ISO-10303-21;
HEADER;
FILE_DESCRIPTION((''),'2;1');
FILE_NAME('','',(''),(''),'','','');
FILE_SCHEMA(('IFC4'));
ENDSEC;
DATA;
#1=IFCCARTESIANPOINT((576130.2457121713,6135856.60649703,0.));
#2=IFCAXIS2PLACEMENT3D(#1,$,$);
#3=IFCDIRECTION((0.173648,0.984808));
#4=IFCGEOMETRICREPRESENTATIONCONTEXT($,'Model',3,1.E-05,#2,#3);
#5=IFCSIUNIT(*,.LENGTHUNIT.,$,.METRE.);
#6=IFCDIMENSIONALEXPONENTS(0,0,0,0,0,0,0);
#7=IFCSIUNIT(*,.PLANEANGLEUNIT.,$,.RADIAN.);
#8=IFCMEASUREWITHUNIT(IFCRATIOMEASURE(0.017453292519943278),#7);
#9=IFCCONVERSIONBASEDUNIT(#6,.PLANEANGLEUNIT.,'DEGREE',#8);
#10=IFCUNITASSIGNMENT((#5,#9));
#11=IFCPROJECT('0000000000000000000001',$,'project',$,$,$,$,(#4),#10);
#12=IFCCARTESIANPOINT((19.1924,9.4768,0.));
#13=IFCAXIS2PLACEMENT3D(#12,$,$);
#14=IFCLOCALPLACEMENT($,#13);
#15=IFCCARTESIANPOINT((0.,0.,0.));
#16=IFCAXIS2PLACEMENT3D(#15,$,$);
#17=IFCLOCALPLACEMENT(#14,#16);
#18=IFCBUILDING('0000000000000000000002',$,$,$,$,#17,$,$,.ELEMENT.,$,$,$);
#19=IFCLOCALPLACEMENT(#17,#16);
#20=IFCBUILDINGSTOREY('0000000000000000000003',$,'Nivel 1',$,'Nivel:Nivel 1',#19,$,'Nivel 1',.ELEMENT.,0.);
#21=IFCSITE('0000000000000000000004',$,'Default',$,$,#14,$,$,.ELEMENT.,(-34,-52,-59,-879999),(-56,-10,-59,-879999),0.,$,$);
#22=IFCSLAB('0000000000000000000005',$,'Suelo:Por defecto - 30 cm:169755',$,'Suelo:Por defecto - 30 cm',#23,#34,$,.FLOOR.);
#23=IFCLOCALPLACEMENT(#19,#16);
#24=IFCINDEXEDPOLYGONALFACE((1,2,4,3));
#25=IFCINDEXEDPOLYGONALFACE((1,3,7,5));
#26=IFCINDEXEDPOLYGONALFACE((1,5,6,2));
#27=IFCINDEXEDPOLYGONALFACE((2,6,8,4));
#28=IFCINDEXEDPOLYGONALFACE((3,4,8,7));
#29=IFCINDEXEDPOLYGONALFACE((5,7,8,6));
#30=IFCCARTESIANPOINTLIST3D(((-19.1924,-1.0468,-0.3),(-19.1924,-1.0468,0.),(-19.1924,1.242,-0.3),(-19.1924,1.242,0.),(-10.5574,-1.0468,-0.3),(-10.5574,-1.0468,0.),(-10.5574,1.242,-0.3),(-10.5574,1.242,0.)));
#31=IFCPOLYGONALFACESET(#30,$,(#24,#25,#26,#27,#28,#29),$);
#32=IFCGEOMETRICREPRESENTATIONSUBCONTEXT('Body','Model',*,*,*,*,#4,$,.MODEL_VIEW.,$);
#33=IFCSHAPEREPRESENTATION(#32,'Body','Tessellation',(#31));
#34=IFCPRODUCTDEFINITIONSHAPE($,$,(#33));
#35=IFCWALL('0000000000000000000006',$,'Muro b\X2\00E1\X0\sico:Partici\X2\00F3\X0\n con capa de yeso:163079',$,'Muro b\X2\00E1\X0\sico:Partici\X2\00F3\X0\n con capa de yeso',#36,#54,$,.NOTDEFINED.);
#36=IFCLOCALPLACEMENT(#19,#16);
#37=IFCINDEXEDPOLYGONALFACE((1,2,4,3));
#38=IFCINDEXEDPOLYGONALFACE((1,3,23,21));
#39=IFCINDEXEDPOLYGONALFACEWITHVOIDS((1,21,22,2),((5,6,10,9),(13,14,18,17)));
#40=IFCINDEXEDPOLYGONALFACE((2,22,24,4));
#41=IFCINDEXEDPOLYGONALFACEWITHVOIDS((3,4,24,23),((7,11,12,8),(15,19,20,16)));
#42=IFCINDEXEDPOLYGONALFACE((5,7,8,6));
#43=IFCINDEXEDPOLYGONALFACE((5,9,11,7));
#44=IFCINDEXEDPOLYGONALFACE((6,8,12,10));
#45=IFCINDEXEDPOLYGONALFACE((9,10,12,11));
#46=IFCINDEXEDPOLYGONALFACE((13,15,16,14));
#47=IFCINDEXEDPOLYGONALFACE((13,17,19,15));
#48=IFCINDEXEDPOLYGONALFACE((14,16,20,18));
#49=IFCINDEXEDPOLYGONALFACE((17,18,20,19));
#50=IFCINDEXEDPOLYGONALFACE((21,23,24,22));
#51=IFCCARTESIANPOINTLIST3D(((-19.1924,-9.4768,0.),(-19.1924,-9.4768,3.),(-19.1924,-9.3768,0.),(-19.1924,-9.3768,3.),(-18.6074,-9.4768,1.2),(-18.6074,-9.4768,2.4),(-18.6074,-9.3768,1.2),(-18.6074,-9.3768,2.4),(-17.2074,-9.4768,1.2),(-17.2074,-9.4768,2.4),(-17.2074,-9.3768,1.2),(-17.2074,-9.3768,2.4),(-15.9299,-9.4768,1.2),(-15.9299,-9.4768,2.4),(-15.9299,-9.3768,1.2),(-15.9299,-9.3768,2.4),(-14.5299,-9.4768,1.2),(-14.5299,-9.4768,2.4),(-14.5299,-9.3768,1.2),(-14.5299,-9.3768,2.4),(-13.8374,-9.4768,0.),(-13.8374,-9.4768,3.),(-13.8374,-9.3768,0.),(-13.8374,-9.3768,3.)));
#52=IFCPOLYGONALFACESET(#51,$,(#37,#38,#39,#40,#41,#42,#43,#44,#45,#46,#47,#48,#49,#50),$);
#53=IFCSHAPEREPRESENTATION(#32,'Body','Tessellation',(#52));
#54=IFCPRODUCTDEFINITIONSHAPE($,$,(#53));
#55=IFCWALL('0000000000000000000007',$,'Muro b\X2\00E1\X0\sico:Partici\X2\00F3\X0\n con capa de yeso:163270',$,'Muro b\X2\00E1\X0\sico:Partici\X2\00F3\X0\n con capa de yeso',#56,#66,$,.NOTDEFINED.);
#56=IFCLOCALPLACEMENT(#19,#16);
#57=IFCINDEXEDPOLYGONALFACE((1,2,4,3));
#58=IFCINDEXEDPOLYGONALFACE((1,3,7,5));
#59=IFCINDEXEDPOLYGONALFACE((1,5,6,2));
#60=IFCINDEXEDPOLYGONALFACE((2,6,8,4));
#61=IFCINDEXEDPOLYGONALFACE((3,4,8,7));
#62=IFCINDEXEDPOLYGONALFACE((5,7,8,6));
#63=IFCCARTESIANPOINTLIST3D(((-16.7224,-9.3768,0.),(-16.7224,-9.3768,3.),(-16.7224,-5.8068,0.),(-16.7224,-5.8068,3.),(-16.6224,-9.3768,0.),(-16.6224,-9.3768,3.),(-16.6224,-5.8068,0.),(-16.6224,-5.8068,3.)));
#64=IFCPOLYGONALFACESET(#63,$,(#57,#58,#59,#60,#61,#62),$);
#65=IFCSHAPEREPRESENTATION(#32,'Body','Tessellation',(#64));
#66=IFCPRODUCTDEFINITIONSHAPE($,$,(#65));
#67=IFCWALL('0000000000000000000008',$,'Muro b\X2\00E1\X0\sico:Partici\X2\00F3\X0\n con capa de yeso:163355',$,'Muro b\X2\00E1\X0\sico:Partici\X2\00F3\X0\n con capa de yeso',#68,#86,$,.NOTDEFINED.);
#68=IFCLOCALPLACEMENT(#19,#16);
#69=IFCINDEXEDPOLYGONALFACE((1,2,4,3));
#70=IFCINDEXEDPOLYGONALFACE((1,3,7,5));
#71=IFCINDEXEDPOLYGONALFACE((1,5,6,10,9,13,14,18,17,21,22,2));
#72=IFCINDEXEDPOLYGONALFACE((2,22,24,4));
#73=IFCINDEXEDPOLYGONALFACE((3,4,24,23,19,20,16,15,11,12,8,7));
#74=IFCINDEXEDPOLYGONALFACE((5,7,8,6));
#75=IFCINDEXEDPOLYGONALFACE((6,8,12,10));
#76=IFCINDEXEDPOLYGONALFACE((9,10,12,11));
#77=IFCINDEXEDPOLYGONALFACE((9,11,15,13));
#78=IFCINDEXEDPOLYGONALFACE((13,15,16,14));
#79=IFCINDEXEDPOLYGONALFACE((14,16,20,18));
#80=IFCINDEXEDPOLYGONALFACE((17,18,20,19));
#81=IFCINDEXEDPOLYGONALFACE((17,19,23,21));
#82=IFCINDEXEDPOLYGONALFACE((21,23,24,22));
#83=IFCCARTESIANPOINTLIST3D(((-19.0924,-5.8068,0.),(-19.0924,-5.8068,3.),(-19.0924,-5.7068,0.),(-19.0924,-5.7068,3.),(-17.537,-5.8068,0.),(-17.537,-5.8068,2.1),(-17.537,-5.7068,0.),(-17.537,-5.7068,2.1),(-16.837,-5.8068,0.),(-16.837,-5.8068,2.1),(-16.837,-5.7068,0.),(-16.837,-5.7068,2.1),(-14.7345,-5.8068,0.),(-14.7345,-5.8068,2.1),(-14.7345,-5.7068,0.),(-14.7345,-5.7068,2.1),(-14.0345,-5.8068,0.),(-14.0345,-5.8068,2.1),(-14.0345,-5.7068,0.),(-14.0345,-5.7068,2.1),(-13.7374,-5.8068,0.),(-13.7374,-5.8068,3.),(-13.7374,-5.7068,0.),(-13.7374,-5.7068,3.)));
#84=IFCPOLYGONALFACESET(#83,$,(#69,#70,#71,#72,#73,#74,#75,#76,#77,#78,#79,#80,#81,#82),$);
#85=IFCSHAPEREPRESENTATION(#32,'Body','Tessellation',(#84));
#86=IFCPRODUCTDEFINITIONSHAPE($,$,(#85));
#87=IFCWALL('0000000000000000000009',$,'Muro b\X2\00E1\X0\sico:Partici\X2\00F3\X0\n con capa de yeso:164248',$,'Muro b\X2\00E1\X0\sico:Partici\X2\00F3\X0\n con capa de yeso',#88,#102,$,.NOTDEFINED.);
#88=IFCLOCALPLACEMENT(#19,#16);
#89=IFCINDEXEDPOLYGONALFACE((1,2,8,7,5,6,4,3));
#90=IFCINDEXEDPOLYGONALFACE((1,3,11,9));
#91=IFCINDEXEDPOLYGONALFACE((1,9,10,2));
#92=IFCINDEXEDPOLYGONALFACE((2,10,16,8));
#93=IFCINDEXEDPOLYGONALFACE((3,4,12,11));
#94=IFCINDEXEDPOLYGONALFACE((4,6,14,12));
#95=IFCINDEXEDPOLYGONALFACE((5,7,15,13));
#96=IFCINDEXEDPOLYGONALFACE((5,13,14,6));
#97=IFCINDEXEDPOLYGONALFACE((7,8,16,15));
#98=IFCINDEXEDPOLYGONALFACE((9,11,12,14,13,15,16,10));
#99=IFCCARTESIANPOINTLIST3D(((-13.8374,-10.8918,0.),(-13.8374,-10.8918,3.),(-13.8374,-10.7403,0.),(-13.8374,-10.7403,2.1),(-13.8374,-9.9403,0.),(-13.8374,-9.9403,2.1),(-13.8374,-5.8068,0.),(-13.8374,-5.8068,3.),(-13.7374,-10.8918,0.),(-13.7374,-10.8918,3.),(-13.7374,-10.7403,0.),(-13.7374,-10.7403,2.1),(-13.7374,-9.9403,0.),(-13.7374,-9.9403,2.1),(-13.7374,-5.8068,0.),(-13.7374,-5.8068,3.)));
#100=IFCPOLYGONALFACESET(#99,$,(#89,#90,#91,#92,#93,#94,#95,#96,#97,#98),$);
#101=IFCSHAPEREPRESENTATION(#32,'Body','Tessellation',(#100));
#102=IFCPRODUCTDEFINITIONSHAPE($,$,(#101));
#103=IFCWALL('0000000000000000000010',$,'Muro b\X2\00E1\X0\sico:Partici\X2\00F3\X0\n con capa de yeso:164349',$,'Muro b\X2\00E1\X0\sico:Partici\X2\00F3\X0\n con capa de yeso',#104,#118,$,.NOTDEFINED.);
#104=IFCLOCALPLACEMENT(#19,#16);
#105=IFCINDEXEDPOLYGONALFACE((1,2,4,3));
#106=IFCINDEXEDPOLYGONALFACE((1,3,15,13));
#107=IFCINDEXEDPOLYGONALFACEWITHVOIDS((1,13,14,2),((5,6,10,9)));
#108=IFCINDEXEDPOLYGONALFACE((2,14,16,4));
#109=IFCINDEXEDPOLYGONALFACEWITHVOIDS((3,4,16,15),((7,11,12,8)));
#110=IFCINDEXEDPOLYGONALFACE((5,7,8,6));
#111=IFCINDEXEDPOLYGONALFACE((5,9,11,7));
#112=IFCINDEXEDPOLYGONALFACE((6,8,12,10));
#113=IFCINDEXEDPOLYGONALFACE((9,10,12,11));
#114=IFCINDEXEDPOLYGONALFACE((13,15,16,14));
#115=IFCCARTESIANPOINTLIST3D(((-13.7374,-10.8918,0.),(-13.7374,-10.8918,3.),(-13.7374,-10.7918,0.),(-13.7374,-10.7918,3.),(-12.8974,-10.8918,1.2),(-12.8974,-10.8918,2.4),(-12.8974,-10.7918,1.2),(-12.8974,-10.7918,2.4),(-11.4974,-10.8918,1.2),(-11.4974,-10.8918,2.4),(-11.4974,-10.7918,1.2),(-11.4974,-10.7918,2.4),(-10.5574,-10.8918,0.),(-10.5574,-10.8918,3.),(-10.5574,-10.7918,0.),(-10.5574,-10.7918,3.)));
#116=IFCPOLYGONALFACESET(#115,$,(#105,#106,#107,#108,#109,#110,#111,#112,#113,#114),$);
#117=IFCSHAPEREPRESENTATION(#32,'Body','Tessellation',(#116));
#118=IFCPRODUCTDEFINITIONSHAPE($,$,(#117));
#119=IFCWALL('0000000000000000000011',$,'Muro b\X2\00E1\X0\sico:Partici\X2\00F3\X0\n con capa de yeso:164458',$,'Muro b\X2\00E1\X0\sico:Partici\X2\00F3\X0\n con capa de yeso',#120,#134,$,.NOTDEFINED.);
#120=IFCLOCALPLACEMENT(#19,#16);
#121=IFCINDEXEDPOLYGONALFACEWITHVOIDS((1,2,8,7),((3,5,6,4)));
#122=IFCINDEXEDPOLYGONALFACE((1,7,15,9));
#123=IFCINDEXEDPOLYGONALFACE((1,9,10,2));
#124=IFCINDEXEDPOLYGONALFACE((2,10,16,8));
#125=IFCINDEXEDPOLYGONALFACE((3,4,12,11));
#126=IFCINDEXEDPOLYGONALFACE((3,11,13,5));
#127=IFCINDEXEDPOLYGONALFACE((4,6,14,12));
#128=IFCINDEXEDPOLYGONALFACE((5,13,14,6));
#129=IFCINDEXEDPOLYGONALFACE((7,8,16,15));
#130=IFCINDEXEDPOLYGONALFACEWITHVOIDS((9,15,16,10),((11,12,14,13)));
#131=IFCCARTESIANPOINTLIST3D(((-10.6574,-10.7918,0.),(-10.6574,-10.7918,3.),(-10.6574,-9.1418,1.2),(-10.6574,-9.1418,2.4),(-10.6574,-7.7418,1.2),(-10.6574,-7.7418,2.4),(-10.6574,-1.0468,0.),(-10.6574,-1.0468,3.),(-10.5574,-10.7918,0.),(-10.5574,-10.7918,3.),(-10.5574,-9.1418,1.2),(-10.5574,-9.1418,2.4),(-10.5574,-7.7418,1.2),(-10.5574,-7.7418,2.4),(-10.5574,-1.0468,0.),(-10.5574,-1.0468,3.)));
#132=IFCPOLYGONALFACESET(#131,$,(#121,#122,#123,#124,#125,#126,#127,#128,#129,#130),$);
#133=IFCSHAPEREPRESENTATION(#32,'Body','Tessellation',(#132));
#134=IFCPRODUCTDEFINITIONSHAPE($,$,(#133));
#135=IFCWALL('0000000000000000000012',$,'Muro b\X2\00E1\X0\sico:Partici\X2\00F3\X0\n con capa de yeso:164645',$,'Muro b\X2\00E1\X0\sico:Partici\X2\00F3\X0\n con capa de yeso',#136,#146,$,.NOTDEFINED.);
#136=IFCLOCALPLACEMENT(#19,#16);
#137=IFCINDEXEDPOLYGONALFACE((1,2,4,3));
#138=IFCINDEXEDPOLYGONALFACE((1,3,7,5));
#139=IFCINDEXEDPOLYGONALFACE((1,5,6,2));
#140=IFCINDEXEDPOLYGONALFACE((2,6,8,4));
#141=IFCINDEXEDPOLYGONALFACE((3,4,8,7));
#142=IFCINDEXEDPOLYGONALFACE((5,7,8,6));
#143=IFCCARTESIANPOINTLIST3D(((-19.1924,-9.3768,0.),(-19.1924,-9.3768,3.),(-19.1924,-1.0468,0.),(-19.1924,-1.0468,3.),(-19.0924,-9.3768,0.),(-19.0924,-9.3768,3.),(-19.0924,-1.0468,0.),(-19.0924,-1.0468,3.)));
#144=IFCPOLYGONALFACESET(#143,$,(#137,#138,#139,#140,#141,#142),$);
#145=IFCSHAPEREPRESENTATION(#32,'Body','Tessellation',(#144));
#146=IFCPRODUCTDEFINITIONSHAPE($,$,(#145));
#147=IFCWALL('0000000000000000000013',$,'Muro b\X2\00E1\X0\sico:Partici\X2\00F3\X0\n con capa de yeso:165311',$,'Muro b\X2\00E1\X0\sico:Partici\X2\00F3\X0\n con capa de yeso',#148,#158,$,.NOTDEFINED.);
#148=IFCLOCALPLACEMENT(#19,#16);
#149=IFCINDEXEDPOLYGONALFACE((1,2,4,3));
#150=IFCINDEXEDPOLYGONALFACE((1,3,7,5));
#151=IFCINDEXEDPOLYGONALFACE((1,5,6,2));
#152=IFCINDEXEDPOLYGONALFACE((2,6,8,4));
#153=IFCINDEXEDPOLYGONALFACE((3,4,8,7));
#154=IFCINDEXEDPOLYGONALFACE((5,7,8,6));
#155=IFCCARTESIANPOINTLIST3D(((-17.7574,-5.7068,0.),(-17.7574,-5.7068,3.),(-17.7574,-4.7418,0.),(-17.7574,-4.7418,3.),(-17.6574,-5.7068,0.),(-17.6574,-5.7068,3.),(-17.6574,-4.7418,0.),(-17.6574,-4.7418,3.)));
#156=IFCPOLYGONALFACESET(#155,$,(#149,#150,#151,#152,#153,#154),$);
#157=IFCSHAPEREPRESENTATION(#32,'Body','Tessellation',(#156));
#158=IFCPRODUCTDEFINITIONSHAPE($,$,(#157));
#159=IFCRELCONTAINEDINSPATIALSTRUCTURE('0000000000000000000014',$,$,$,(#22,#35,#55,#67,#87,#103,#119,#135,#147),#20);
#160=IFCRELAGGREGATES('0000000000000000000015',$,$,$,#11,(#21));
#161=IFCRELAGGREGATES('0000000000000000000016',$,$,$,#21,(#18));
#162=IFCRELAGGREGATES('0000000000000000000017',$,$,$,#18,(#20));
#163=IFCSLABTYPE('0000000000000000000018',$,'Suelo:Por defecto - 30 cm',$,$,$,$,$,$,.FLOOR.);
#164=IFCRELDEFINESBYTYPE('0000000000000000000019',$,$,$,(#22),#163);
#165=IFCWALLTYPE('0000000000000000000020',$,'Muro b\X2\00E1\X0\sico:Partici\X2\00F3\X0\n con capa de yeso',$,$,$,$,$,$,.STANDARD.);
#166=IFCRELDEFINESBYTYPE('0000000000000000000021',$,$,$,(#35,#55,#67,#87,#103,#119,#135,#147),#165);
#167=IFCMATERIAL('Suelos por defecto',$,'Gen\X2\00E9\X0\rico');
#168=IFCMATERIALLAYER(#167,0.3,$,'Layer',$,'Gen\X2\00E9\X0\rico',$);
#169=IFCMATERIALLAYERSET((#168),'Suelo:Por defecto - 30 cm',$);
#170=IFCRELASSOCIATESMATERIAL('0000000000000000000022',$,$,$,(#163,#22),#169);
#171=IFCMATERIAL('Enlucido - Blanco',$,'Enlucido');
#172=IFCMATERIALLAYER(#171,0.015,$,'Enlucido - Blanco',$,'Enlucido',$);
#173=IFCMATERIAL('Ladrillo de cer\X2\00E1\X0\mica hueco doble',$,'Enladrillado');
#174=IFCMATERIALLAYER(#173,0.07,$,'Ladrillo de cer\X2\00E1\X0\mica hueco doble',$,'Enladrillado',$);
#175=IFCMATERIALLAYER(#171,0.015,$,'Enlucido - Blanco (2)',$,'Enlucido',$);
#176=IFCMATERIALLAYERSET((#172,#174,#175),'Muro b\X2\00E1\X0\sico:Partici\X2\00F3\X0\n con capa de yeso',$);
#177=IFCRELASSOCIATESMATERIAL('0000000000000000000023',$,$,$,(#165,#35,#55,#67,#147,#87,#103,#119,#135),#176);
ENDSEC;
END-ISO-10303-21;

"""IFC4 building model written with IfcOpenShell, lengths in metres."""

from ifc_helpers import new_model, entity, si_unit, converted_unit, direction, frame, frame_2d, origin, origin_2d_with_axis, place, context, subcontext, project, spatial, rectangle, extrude, material, layer, layer_set, layer_usage, type_object, element, save


model = new_model("IFC4")

# Units and contexts
model_context = context("Model", 3, precision=1e-05, world=frame((576130.2457121713, 6135856.60649703, 0.0)), true_north=direction((0.173648, 0.984808)))
body_context = subcontext(model_context, "Body", "Model", "MODEL_VIEW")
ifc_project = project(units=[si_unit("LENGTHUNIT", "METRE"), converted_unit("PLANEANGLEUNIT", "DEGREE", entity("IfcRatioMeasure", 0.017453292519943278), si_unit("PLANEANGLEUNIT", "RADIAN"), dimensions=[0, 0, 0, 0, 0, 0, 0])], contexts=[model_context])

# Site, building, storey
site_placement = place(None, frame((19.1924, 9.4768, 0.0)))
site = spatial("IfcSite", under=ifc_project, at=site_placement, Name="Default", CompositionType="ELEMENT", RefLatitude=(-34, -52, -59, -879999), RefLongitude=(-56, -10, -59, -879999), RefElevation=0.0)
building_placement = place(site_placement, origin())
building = spatial("IfcBuilding", under=site, at=building_placement, CompositionType="ELEMENT")
storey_placement = place(building_placement, origin())
storey = spatial("IfcBuildingStorey", under=building, at=storey_placement, Name="Nivel 1", ObjectType="Nivel:Nivel 1", LongName="Nivel 1", CompositionType="ELEMENT", Elevation=0.0)

# Slab
ifc_material_1 = material(Name="Suelos por defecto", Category="Genérico")
ifc_layer_1 = layer(ifc_material_1, 0.3, Name="Layer", Category="Genérico")
ifc_layer_set_1 = layer_set([ifc_layer_1], Name="Suelo:Por defecto - 30 cm")
ifc_layer_usage_1 = layer_usage(ifc_layer_set_1, "AXIS3", "POSITIVE", 0.0)
slab_type = type_object("IfcSlabType", Name="Suelo:Por defecto - 30 cm", PredefinedType="FLOOR", material=ifc_layer_set_1)
slab_1_placement = place(storey_placement, origin())
element("IfcSlab", 1, at=slab_1_placement, inside=storey, type_object=slab_type, material=ifc_layer_usage_1, Name="Suelo:Por defecto - 30 cm:169755", ObjectType="Suelo:Por defecto - 30 cm", PredefinedType="FLOOR", context=body_context, shape_type="SweptSolid", body=[
    extrude(rectangle(XDim=2.2888, YDim=8.635, at=origin_2d_with_axis()), frame((-14.8749, 0.0976, 0.0), z_axis=(0.0, 0.0, -1.0), x_axis=(0.0, 1.0, 0.0)), (0.0, 0.0, 1.0), 0.3),
])

# Wall, openings
ifc_material_2 = material(Name="Enlucido - Blanco", Category="Enlucido")
ifc_layer_2 = layer(ifc_material_2, 0.015, Name="Enlucido - Blanco", Category="Enlucido")
ifc_material_3 = material(Name="Ladrillo de cerámica hueco doble", Category="Enladrillado")
ifc_layer_3 = layer(ifc_material_3, 0.07, Name="Ladrillo de cerámica hueco doble", Category="Enladrillado")
ifc_layer_4 = layer(ifc_material_2, 0.015, Name="Enlucido - Blanco (2)", Category="Enlucido")
ifc_layer_set_2 = layer_set([ifc_layer_2, ifc_layer_3, ifc_layer_4], Name="Muro básico:Partición con capa de yeso")
ifc_layer_usage_2 = layer_usage(ifc_layer_set_2, "AXIS2", "NEGATIVE", 0.05)
wall_type = type_object("IfcWallType", Name="Muro básico:Partición con capa de yeso", PredefinedType="STANDARD", material=ifc_layer_set_2)
wall_1_placement = place(storey_placement, frame((-19.1924, -9.4268, 0.0)))
wall_1 = element("IfcWall", 2, at=wall_1_placement, inside=storey, type_object=wall_type, material=ifc_layer_usage_2, Name="Muro básico:Partición con capa de yeso:163079", ObjectType="Muro básico:Partición con capa de yeso", PredefinedType="NOTDEFINED", context=body_context, shape_type="SweptSolid", body=[
    extrude(rectangle(XDim=5.355, YDim=0.1, at=frame_2d((2.6775, 0.0), x_axis=(-1.0, 0.0))), origin(), (0.0, 0.0, 1.0), 3.0),
])
opening_1_placement = place(wall_1_placement, frame((0.585, -0.05, 1.2)))
element("IfcOpeningElement", 3, at=opening_1_placement, cuts=wall_1, PredefinedType="OPENING", context=body_context, shape_type="SweptSolid", body=[
    extrude(rectangle(XDim=1.2, YDim=1.4, at=frame_2d((0.6, 0.7), x_axis=(1.0, 0.0))), frame((0.0, 0.0, 0.0), z_axis=(0.0, 1.0, 0.0), x_axis=(0.0, 0.0, 1.0)), (0.0, 0.0, 1.0), 0.1),
])
opening_2_placement = place(wall_1_placement, frame((3.2625, -0.05, 1.2)))
element("IfcOpeningElement", 4, at=opening_2_placement, cuts=wall_1, PredefinedType="OPENING", context=body_context, shape_type="SweptSolid", body=[
    extrude(rectangle(XDim=1.2, YDim=1.4, at=frame_2d((0.6, 0.7), x_axis=(1.0, 0.0))), frame((0.0, 0.0, 0.0), z_axis=(0.0, 1.0, 0.0), x_axis=(0.0, 0.0, 1.0)), (0.0, 0.0, 1.0), 0.1),
])

# Wall
wall_2_placement = place(storey_placement, frame((-16.6724, -9.3768, 0.0), z_axis=(0.0, 0.0, 1.0), x_axis=(0.0, 1.0, 0.0)))
element("IfcWall", 5, at=wall_2_placement, inside=storey, type_object=wall_type, material=ifc_layer_usage_2, Name="Muro básico:Partición con capa de yeso:163270", ObjectType="Muro básico:Partición con capa de yeso", PredefinedType="NOTDEFINED", context=body_context, shape_type="SweptSolid", body=[
    extrude(rectangle(XDim=3.57, YDim=0.1, at=frame_2d((1.785, 0.0), x_axis=(-1.0, 0.0))), origin(), (0.0, 0.0, 1.0), 3.0),
])

# Wall, openings
wall_3_placement = place(storey_placement, frame((-13.7374, -5.7568, 0.0), z_axis=(0.0, 0.0, 1.0), x_axis=(-1.0, 0.0, 0.0)))
wall_3 = element("IfcWall", 6, at=wall_3_placement, inside=storey, type_object=wall_type, material=ifc_layer_usage_2, Name="Muro básico:Partición con capa de yeso:163355", ObjectType="Muro básico:Partición con capa de yeso", PredefinedType="NOTDEFINED", context=body_context, shape_type="SweptSolid", body=[
    extrude(rectangle(XDim=5.355, YDim=0.1, at=frame_2d((2.6775, 0.0), x_axis=(-1.0, 0.0))), origin(), (0.0, 0.0, 1.0), 3.0),
])
opening_3_placement = place(wall_3_placement, frame((3.0996, -0.05, 0.0)))
element("IfcOpeningElement", 7, at=opening_3_placement, cuts=wall_3, PredefinedType="OPENING", context=body_context, shape_type="SweptSolid", body=[
    extrude(rectangle(XDim=2.1, YDim=0.7, at=frame_2d((1.05, 0.35), x_axis=(1.0, 0.0))), frame((0.0, 0.0, 0.0), z_axis=(0.0, 1.0, 0.0), x_axis=(0.0, 0.0, 1.0)), (0.0, 0.0, 1.0), 0.1),
])
opening_4_placement = place(wall_3_placement, frame((0.2971, -0.05, 0.0)))
element("IfcOpeningElement", 8, at=opening_4_placement, cuts=wall_3, PredefinedType="OPENING", context=body_context, shape_type="SweptSolid", body=[
    extrude(rectangle(XDim=2.1, YDim=0.7, at=frame_2d((1.05, 0.35), x_axis=(1.0, 0.0))), frame((0.0, 0.0, 0.0), z_axis=(0.0, 1.0, 0.0), x_axis=(0.0, 0.0, 1.0)), (0.0, 0.0, 1.0), 0.1),
])

# Walls, openings
ifc_layer_usage_3 = layer_usage(ifc_layer_set_2, "AXIS2", "POSITIVE", -0.05)
wall_4_placement = place(storey_placement, frame((-13.7874, -5.8068, 0.0), z_axis=(0.0, 0.0, 1.0), x_axis=(0.0, -1.0, 0.0)))
wall_4 = element("IfcWall", 9, at=wall_4_placement, inside=storey, type_object=wall_type, material=ifc_layer_usage_3, Name="Muro básico:Partición con capa de yeso:164248", ObjectType="Muro básico:Partición con capa de yeso", PredefinedType="NOTDEFINED", context=body_context, shape_type="SweptSolid", body=[
    extrude(rectangle(XDim=5.085, YDim=0.1, at=frame_2d((2.5425, 0.0), x_axis=(1.0, 0.0))), origin(), (0.0, 0.0, 1.0), 3.0),
])
opening_5_placement = place(wall_4_placement, frame((4.1335, -0.05, 0.0)))
element("IfcOpeningElement", 10, at=opening_5_placement, cuts=wall_4, PredefinedType="OPENING", context=body_context, shape_type="SweptSolid", body=[
    extrude(rectangle(XDim=2.1, YDim=0.8, at=frame_2d((1.05, 0.4), x_axis=(1.0, 0.0))), frame((0.0, 0.0, 0.0), z_axis=(0.0, 1.0, 0.0), x_axis=(0.0, 0.0, 1.0)), (0.0, 0.0, 1.0), 0.1),
])
wall_5_placement = place(storey_placement, frame((-13.7374, -10.8418, 0.0)))
wall_5 = element("IfcWall", 11, at=wall_5_placement, inside=storey, type_object=wall_type, material=ifc_layer_usage_3, Name="Muro básico:Partición con capa de yeso:164349", ObjectType="Muro básico:Partición con capa de yeso", PredefinedType="NOTDEFINED", context=body_context, shape_type="SweptSolid", body=[
    extrude(rectangle(XDim=3.18, YDim=0.1, at=frame_2d((1.59, 0.0), x_axis=(-1.0, 0.0))), origin(), (0.0, 0.0, 1.0), 3.0),
])
opening_6_placement = place(wall_5_placement, frame((0.84, -0.05, 1.2)))
element("IfcOpeningElement", 12, at=opening_6_placement, cuts=wall_5, PredefinedType="OPENING", context=body_context, shape_type="SweptSolid", body=[
    extrude(rectangle(XDim=1.2, YDim=1.4, at=frame_2d((0.6, 0.7), x_axis=(1.0, 0.0))), frame((0.0, 0.0, 0.0), z_axis=(0.0, 1.0, 0.0), x_axis=(0.0, 0.0, 1.0)), (0.0, 0.0, 1.0), 0.1),
])
wall_6_placement = place(storey_placement, frame((-10.6074, -10.7918, 0.0), z_axis=(0.0, 0.0, 1.0), x_axis=(0.0, 1.0, 0.0)))
wall_6 = element("IfcWall", 13, at=wall_6_placement, inside=storey, type_object=wall_type, material=ifc_layer_usage_3, Name="Muro básico:Partición con capa de yeso:164458", ObjectType="Muro básico:Partición con capa de yeso", PredefinedType="NOTDEFINED", context=body_context, shape_type="SweptSolid", body=[
    extrude(rectangle(XDim=9.745, YDim=0.1, at=frame_2d((4.8725, 0.0), x_axis=(-1.0, 0.0))), origin(), (0.0, 0.0, 1.0), 3.0),
])
opening_7_placement = place(wall_6_placement, frame((1.65, -0.05, 1.2)))
element("IfcOpeningElement", 14, at=opening_7_placement, cuts=wall_6, PredefinedType="OPENING", context=body_context, shape_type="SweptSolid", body=[
    extrude(rectangle(XDim=1.2, YDim=1.4, at=frame_2d((0.6, 0.7), x_axis=(1.0, 0.0))), frame((0.0, 0.0, 0.0), z_axis=(0.0, 1.0, 0.0), x_axis=(0.0, 0.0, 1.0)), (0.0, 0.0, 1.0), 0.1),
])

# Walls
wall_7_placement = place(storey_placement, frame((-19.1424, -1.0468, 0.0), z_axis=(0.0, 0.0, 1.0), x_axis=(0.0, -1.0, 0.0)))
element("IfcWall", 15, at=wall_7_placement, inside=storey, type_object=wall_type, material=ifc_layer_usage_3, Name="Muro básico:Partición con capa de yeso:164645", ObjectType="Muro básico:Partición con capa de yeso", PredefinedType="NOTDEFINED", context=body_context, shape_type="SweptSolid", body=[
    extrude(rectangle(XDim=8.33, YDim=0.1, at=frame_2d((4.165, 0.0), x_axis=(-1.0, 0.0))), origin(), (0.0, 0.0, 1.0), 3.0),
])
wall_8_placement = place(storey_placement, frame((-17.7074, -5.7068, 0.0), z_axis=(0.0, 0.0, 1.0), x_axis=(0.0, 1.0, 0.0)))
element("IfcWall", 16, at=wall_8_placement, inside=storey, type_object=wall_type, material=ifc_layer_usage_2, Name="Muro básico:Partición con capa de yeso:165311", ObjectType="Muro básico:Partición con capa de yeso", PredefinedType="NOTDEFINED", context=body_context, shape_type="SweptSolid", body=[
    extrude(rectangle(XDim=0.965, YDim=0.1, at=frame_2d((0.4825, 0.0), x_axis=(-1.0, 0.0))), origin(), (0.0, 0.0, 1.0), 3.0),
])

save(model, "model.ifc")
